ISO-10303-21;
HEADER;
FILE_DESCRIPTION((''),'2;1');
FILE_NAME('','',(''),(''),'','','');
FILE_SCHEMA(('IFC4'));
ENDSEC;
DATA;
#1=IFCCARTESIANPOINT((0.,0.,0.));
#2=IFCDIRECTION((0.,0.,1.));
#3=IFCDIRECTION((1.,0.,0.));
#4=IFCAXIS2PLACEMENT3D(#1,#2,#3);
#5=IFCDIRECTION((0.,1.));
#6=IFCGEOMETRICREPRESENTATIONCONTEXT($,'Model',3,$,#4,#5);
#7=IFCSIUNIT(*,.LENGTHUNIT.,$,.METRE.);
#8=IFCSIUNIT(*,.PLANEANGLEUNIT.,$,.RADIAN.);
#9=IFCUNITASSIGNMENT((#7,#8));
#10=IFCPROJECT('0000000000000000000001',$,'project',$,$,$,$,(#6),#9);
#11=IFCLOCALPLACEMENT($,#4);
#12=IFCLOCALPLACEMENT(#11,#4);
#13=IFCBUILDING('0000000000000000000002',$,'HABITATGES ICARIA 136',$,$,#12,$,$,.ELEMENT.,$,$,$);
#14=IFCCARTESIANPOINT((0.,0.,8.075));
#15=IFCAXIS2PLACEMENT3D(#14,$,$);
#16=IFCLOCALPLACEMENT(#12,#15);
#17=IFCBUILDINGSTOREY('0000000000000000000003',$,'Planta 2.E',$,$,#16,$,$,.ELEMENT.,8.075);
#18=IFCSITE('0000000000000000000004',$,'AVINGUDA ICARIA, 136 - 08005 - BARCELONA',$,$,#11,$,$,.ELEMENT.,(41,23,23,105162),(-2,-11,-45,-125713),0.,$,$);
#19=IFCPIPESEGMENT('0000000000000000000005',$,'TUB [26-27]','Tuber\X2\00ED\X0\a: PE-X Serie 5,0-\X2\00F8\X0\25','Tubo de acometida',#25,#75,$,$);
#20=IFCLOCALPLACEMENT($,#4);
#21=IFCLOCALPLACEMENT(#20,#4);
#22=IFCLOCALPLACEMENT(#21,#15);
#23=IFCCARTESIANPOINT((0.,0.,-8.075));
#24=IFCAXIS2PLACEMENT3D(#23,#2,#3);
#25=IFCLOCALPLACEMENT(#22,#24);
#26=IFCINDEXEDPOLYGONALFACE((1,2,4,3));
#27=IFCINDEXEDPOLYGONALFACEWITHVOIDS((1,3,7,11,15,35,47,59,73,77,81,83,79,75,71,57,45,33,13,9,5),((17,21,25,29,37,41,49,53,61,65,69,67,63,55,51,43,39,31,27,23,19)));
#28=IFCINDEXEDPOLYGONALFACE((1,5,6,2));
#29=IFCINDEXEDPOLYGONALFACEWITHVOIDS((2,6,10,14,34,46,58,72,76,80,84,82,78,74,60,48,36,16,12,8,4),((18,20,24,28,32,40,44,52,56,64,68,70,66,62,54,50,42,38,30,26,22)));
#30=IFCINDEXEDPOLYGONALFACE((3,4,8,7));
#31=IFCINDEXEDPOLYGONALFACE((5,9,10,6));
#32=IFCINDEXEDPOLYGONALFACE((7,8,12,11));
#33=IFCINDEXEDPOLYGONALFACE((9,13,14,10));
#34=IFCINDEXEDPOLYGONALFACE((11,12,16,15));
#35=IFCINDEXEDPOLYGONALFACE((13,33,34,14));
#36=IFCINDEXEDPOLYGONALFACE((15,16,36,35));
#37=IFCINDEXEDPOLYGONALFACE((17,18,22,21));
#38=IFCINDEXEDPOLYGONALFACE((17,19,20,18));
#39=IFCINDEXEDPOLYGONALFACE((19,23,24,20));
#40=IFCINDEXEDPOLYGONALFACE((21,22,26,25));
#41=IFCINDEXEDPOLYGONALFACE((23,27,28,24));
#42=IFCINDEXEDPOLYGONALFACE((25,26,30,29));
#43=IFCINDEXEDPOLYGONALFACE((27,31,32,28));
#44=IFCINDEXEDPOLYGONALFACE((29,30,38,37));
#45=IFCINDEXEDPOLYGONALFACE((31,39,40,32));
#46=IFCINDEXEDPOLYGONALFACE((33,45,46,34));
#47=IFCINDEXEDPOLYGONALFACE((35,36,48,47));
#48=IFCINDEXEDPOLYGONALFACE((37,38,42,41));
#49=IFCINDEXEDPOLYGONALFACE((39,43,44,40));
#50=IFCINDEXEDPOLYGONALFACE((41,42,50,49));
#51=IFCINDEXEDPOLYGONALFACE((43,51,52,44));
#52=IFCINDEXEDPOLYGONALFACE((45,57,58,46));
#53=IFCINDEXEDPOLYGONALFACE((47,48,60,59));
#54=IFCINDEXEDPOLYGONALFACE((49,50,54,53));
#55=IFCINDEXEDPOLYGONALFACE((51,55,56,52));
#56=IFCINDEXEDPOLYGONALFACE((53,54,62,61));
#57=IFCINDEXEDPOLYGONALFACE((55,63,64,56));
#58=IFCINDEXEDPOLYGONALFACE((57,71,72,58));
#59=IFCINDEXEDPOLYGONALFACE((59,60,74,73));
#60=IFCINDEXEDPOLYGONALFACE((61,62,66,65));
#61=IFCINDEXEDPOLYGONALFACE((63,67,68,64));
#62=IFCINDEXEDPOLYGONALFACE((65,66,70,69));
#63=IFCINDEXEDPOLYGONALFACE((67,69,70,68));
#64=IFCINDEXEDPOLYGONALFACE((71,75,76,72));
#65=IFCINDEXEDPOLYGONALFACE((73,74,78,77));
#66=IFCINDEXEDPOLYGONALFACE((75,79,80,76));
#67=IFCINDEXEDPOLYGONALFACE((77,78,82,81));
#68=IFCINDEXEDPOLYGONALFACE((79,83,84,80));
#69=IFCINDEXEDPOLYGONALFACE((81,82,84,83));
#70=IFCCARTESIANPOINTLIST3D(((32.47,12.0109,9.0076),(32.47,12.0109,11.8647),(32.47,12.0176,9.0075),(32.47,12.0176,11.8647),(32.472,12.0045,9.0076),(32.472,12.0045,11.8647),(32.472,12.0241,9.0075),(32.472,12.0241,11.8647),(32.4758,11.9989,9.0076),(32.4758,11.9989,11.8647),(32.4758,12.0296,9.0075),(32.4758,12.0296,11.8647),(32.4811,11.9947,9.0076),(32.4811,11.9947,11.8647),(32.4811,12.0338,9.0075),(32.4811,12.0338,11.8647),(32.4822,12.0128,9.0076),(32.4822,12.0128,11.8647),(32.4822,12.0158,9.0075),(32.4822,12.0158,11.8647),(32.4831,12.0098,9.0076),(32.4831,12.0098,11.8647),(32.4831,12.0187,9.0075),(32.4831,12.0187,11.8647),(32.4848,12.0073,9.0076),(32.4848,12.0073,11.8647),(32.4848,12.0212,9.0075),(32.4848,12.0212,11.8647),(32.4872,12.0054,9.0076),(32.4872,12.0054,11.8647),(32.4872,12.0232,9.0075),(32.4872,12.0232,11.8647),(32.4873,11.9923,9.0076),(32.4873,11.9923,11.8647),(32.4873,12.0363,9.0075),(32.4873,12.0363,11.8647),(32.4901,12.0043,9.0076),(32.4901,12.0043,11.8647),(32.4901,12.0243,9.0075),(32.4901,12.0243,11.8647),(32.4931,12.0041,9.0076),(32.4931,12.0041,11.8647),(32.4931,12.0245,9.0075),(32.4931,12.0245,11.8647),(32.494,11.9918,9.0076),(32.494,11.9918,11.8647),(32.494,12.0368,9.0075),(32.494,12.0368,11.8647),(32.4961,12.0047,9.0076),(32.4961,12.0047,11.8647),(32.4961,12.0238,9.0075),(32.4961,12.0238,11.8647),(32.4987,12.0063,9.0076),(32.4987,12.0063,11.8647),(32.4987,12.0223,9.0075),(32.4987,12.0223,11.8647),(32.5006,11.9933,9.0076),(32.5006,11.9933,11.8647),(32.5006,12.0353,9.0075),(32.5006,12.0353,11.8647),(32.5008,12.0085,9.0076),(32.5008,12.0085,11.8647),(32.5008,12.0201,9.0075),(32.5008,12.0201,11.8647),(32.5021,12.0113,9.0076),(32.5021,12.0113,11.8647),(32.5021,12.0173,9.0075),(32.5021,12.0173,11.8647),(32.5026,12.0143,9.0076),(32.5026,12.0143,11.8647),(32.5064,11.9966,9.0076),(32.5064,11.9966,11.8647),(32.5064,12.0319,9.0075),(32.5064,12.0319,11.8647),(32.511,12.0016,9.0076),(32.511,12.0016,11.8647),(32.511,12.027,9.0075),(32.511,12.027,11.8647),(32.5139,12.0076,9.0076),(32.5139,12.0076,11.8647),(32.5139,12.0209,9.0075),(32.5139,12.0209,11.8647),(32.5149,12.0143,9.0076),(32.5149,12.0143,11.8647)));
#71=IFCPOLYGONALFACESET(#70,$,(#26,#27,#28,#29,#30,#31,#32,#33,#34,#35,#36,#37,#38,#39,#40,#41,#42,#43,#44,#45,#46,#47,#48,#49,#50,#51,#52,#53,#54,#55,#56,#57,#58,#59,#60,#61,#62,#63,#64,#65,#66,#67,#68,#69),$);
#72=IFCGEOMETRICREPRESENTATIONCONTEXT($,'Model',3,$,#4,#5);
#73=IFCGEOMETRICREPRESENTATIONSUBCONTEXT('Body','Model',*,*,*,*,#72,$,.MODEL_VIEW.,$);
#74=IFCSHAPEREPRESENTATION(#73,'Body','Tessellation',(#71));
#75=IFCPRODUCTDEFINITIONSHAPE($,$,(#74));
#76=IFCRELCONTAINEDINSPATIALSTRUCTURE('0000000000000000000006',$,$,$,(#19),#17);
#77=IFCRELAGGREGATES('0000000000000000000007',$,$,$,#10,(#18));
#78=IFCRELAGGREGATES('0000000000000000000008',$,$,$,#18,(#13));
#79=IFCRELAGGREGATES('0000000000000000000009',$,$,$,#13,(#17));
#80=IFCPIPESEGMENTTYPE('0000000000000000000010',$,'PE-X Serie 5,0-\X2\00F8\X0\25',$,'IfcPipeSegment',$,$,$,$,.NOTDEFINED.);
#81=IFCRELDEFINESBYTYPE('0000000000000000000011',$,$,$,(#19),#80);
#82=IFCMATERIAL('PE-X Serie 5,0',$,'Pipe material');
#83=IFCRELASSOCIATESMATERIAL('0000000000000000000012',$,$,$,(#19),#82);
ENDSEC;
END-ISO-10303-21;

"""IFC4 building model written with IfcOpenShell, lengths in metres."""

from ifc_helpers import new_model, si_unit, direction, frame, origin_with_axes, origin_2d_with_axis, place, context, subcontext, project, spatial, hollow_circle, extrude, material, type_object, element, save


model = new_model("IFC4")

# Units and contexts
model_context_1 = context("Model", 3, world=origin_with_axes(), true_north=direction((0.0, 1.0)))
model_context_2 = context("Model", 3, world=origin_with_axes(), true_north=direction((0.0, 1.0)))
body_context_1 = subcontext(model_context_2, "Body", "Model", "MODEL_VIEW")
ifc_project = project(units=[si_unit("LENGTHUNIT", "METRE"), si_unit("PLANEANGLEUNIT", "RADIAN")], contexts=[model_context_1])

# Site, building, storey
site_placement = place(None, origin_with_axes())
site = spatial("IfcSite", under=ifc_project, at=site_placement, Name="AVINGUDA ICARIA, 136 - 08005 - BARCELONA", CompositionType="ELEMENT", RefLatitude=(41, 23, 23, 105162), RefLongitude=(-2, -11, -45, -125713), RefElevation=0.0)
building_placement = place(site_placement, origin_with_axes())
building = spatial("IfcBuilding", under=site, at=building_placement, Name="HABITATGES ICARIA 136", CompositionType="ELEMENT")
storey_placement = place(building_placement, frame((0.0, 0.0, 8.075)))
storey = spatial("IfcBuildingStorey", under=building, at=storey_placement, Name="Planta 2.E", CompositionType="ELEMENT", Elevation=8.075)

# Pipe segment
ifc_material_1 = material(Name="PE-X Serie 5,0", Category="Pipe material")
pipe_segment_type = type_object("IfcPipeSegmentType", Name="PE-X Serie 5,0-ø25", ApplicableOccurrence="IfcPipeSegment", PredefinedType="NOTDEFINED")
placement_1 = place(None, origin_with_axes())
placement_2 = place(placement_1, origin_with_axes())
placement_3 = place(placement_2, frame((0.0, 0.0, 8.075)))
pipe_segment_1_placement = place(placement_3, frame((0.0, 0.0, -8.075), z_axis=(0.0, 0.0, 1.0), x_axis=(1.0, 0.0, 0.0)))
element("IfcPipeSegment", 1, at=pipe_segment_1_placement, inside=storey, type_object=pipe_segment_type, material=ifc_material_1, Name="TUB [26-27]", Description="Tubería: PE-X Serie 5,0-ø25", ObjectType="Tubo de acometida", context=body_context_1, shape_type="SweptSolid", body=[
    extrude(hollow_circle(Radius=0.0226, WallThickness=0.0123, at=origin_2d_with_axis()), frame((32.4923, 12.0143, 9.0076), z_axis=(0.0, 0.0, 1.0), x_axis=(1.0, 0.0, 0.0)), (0.0, 0.0, 1.0), 2.8571),
])

save(model, "model.ifc")
